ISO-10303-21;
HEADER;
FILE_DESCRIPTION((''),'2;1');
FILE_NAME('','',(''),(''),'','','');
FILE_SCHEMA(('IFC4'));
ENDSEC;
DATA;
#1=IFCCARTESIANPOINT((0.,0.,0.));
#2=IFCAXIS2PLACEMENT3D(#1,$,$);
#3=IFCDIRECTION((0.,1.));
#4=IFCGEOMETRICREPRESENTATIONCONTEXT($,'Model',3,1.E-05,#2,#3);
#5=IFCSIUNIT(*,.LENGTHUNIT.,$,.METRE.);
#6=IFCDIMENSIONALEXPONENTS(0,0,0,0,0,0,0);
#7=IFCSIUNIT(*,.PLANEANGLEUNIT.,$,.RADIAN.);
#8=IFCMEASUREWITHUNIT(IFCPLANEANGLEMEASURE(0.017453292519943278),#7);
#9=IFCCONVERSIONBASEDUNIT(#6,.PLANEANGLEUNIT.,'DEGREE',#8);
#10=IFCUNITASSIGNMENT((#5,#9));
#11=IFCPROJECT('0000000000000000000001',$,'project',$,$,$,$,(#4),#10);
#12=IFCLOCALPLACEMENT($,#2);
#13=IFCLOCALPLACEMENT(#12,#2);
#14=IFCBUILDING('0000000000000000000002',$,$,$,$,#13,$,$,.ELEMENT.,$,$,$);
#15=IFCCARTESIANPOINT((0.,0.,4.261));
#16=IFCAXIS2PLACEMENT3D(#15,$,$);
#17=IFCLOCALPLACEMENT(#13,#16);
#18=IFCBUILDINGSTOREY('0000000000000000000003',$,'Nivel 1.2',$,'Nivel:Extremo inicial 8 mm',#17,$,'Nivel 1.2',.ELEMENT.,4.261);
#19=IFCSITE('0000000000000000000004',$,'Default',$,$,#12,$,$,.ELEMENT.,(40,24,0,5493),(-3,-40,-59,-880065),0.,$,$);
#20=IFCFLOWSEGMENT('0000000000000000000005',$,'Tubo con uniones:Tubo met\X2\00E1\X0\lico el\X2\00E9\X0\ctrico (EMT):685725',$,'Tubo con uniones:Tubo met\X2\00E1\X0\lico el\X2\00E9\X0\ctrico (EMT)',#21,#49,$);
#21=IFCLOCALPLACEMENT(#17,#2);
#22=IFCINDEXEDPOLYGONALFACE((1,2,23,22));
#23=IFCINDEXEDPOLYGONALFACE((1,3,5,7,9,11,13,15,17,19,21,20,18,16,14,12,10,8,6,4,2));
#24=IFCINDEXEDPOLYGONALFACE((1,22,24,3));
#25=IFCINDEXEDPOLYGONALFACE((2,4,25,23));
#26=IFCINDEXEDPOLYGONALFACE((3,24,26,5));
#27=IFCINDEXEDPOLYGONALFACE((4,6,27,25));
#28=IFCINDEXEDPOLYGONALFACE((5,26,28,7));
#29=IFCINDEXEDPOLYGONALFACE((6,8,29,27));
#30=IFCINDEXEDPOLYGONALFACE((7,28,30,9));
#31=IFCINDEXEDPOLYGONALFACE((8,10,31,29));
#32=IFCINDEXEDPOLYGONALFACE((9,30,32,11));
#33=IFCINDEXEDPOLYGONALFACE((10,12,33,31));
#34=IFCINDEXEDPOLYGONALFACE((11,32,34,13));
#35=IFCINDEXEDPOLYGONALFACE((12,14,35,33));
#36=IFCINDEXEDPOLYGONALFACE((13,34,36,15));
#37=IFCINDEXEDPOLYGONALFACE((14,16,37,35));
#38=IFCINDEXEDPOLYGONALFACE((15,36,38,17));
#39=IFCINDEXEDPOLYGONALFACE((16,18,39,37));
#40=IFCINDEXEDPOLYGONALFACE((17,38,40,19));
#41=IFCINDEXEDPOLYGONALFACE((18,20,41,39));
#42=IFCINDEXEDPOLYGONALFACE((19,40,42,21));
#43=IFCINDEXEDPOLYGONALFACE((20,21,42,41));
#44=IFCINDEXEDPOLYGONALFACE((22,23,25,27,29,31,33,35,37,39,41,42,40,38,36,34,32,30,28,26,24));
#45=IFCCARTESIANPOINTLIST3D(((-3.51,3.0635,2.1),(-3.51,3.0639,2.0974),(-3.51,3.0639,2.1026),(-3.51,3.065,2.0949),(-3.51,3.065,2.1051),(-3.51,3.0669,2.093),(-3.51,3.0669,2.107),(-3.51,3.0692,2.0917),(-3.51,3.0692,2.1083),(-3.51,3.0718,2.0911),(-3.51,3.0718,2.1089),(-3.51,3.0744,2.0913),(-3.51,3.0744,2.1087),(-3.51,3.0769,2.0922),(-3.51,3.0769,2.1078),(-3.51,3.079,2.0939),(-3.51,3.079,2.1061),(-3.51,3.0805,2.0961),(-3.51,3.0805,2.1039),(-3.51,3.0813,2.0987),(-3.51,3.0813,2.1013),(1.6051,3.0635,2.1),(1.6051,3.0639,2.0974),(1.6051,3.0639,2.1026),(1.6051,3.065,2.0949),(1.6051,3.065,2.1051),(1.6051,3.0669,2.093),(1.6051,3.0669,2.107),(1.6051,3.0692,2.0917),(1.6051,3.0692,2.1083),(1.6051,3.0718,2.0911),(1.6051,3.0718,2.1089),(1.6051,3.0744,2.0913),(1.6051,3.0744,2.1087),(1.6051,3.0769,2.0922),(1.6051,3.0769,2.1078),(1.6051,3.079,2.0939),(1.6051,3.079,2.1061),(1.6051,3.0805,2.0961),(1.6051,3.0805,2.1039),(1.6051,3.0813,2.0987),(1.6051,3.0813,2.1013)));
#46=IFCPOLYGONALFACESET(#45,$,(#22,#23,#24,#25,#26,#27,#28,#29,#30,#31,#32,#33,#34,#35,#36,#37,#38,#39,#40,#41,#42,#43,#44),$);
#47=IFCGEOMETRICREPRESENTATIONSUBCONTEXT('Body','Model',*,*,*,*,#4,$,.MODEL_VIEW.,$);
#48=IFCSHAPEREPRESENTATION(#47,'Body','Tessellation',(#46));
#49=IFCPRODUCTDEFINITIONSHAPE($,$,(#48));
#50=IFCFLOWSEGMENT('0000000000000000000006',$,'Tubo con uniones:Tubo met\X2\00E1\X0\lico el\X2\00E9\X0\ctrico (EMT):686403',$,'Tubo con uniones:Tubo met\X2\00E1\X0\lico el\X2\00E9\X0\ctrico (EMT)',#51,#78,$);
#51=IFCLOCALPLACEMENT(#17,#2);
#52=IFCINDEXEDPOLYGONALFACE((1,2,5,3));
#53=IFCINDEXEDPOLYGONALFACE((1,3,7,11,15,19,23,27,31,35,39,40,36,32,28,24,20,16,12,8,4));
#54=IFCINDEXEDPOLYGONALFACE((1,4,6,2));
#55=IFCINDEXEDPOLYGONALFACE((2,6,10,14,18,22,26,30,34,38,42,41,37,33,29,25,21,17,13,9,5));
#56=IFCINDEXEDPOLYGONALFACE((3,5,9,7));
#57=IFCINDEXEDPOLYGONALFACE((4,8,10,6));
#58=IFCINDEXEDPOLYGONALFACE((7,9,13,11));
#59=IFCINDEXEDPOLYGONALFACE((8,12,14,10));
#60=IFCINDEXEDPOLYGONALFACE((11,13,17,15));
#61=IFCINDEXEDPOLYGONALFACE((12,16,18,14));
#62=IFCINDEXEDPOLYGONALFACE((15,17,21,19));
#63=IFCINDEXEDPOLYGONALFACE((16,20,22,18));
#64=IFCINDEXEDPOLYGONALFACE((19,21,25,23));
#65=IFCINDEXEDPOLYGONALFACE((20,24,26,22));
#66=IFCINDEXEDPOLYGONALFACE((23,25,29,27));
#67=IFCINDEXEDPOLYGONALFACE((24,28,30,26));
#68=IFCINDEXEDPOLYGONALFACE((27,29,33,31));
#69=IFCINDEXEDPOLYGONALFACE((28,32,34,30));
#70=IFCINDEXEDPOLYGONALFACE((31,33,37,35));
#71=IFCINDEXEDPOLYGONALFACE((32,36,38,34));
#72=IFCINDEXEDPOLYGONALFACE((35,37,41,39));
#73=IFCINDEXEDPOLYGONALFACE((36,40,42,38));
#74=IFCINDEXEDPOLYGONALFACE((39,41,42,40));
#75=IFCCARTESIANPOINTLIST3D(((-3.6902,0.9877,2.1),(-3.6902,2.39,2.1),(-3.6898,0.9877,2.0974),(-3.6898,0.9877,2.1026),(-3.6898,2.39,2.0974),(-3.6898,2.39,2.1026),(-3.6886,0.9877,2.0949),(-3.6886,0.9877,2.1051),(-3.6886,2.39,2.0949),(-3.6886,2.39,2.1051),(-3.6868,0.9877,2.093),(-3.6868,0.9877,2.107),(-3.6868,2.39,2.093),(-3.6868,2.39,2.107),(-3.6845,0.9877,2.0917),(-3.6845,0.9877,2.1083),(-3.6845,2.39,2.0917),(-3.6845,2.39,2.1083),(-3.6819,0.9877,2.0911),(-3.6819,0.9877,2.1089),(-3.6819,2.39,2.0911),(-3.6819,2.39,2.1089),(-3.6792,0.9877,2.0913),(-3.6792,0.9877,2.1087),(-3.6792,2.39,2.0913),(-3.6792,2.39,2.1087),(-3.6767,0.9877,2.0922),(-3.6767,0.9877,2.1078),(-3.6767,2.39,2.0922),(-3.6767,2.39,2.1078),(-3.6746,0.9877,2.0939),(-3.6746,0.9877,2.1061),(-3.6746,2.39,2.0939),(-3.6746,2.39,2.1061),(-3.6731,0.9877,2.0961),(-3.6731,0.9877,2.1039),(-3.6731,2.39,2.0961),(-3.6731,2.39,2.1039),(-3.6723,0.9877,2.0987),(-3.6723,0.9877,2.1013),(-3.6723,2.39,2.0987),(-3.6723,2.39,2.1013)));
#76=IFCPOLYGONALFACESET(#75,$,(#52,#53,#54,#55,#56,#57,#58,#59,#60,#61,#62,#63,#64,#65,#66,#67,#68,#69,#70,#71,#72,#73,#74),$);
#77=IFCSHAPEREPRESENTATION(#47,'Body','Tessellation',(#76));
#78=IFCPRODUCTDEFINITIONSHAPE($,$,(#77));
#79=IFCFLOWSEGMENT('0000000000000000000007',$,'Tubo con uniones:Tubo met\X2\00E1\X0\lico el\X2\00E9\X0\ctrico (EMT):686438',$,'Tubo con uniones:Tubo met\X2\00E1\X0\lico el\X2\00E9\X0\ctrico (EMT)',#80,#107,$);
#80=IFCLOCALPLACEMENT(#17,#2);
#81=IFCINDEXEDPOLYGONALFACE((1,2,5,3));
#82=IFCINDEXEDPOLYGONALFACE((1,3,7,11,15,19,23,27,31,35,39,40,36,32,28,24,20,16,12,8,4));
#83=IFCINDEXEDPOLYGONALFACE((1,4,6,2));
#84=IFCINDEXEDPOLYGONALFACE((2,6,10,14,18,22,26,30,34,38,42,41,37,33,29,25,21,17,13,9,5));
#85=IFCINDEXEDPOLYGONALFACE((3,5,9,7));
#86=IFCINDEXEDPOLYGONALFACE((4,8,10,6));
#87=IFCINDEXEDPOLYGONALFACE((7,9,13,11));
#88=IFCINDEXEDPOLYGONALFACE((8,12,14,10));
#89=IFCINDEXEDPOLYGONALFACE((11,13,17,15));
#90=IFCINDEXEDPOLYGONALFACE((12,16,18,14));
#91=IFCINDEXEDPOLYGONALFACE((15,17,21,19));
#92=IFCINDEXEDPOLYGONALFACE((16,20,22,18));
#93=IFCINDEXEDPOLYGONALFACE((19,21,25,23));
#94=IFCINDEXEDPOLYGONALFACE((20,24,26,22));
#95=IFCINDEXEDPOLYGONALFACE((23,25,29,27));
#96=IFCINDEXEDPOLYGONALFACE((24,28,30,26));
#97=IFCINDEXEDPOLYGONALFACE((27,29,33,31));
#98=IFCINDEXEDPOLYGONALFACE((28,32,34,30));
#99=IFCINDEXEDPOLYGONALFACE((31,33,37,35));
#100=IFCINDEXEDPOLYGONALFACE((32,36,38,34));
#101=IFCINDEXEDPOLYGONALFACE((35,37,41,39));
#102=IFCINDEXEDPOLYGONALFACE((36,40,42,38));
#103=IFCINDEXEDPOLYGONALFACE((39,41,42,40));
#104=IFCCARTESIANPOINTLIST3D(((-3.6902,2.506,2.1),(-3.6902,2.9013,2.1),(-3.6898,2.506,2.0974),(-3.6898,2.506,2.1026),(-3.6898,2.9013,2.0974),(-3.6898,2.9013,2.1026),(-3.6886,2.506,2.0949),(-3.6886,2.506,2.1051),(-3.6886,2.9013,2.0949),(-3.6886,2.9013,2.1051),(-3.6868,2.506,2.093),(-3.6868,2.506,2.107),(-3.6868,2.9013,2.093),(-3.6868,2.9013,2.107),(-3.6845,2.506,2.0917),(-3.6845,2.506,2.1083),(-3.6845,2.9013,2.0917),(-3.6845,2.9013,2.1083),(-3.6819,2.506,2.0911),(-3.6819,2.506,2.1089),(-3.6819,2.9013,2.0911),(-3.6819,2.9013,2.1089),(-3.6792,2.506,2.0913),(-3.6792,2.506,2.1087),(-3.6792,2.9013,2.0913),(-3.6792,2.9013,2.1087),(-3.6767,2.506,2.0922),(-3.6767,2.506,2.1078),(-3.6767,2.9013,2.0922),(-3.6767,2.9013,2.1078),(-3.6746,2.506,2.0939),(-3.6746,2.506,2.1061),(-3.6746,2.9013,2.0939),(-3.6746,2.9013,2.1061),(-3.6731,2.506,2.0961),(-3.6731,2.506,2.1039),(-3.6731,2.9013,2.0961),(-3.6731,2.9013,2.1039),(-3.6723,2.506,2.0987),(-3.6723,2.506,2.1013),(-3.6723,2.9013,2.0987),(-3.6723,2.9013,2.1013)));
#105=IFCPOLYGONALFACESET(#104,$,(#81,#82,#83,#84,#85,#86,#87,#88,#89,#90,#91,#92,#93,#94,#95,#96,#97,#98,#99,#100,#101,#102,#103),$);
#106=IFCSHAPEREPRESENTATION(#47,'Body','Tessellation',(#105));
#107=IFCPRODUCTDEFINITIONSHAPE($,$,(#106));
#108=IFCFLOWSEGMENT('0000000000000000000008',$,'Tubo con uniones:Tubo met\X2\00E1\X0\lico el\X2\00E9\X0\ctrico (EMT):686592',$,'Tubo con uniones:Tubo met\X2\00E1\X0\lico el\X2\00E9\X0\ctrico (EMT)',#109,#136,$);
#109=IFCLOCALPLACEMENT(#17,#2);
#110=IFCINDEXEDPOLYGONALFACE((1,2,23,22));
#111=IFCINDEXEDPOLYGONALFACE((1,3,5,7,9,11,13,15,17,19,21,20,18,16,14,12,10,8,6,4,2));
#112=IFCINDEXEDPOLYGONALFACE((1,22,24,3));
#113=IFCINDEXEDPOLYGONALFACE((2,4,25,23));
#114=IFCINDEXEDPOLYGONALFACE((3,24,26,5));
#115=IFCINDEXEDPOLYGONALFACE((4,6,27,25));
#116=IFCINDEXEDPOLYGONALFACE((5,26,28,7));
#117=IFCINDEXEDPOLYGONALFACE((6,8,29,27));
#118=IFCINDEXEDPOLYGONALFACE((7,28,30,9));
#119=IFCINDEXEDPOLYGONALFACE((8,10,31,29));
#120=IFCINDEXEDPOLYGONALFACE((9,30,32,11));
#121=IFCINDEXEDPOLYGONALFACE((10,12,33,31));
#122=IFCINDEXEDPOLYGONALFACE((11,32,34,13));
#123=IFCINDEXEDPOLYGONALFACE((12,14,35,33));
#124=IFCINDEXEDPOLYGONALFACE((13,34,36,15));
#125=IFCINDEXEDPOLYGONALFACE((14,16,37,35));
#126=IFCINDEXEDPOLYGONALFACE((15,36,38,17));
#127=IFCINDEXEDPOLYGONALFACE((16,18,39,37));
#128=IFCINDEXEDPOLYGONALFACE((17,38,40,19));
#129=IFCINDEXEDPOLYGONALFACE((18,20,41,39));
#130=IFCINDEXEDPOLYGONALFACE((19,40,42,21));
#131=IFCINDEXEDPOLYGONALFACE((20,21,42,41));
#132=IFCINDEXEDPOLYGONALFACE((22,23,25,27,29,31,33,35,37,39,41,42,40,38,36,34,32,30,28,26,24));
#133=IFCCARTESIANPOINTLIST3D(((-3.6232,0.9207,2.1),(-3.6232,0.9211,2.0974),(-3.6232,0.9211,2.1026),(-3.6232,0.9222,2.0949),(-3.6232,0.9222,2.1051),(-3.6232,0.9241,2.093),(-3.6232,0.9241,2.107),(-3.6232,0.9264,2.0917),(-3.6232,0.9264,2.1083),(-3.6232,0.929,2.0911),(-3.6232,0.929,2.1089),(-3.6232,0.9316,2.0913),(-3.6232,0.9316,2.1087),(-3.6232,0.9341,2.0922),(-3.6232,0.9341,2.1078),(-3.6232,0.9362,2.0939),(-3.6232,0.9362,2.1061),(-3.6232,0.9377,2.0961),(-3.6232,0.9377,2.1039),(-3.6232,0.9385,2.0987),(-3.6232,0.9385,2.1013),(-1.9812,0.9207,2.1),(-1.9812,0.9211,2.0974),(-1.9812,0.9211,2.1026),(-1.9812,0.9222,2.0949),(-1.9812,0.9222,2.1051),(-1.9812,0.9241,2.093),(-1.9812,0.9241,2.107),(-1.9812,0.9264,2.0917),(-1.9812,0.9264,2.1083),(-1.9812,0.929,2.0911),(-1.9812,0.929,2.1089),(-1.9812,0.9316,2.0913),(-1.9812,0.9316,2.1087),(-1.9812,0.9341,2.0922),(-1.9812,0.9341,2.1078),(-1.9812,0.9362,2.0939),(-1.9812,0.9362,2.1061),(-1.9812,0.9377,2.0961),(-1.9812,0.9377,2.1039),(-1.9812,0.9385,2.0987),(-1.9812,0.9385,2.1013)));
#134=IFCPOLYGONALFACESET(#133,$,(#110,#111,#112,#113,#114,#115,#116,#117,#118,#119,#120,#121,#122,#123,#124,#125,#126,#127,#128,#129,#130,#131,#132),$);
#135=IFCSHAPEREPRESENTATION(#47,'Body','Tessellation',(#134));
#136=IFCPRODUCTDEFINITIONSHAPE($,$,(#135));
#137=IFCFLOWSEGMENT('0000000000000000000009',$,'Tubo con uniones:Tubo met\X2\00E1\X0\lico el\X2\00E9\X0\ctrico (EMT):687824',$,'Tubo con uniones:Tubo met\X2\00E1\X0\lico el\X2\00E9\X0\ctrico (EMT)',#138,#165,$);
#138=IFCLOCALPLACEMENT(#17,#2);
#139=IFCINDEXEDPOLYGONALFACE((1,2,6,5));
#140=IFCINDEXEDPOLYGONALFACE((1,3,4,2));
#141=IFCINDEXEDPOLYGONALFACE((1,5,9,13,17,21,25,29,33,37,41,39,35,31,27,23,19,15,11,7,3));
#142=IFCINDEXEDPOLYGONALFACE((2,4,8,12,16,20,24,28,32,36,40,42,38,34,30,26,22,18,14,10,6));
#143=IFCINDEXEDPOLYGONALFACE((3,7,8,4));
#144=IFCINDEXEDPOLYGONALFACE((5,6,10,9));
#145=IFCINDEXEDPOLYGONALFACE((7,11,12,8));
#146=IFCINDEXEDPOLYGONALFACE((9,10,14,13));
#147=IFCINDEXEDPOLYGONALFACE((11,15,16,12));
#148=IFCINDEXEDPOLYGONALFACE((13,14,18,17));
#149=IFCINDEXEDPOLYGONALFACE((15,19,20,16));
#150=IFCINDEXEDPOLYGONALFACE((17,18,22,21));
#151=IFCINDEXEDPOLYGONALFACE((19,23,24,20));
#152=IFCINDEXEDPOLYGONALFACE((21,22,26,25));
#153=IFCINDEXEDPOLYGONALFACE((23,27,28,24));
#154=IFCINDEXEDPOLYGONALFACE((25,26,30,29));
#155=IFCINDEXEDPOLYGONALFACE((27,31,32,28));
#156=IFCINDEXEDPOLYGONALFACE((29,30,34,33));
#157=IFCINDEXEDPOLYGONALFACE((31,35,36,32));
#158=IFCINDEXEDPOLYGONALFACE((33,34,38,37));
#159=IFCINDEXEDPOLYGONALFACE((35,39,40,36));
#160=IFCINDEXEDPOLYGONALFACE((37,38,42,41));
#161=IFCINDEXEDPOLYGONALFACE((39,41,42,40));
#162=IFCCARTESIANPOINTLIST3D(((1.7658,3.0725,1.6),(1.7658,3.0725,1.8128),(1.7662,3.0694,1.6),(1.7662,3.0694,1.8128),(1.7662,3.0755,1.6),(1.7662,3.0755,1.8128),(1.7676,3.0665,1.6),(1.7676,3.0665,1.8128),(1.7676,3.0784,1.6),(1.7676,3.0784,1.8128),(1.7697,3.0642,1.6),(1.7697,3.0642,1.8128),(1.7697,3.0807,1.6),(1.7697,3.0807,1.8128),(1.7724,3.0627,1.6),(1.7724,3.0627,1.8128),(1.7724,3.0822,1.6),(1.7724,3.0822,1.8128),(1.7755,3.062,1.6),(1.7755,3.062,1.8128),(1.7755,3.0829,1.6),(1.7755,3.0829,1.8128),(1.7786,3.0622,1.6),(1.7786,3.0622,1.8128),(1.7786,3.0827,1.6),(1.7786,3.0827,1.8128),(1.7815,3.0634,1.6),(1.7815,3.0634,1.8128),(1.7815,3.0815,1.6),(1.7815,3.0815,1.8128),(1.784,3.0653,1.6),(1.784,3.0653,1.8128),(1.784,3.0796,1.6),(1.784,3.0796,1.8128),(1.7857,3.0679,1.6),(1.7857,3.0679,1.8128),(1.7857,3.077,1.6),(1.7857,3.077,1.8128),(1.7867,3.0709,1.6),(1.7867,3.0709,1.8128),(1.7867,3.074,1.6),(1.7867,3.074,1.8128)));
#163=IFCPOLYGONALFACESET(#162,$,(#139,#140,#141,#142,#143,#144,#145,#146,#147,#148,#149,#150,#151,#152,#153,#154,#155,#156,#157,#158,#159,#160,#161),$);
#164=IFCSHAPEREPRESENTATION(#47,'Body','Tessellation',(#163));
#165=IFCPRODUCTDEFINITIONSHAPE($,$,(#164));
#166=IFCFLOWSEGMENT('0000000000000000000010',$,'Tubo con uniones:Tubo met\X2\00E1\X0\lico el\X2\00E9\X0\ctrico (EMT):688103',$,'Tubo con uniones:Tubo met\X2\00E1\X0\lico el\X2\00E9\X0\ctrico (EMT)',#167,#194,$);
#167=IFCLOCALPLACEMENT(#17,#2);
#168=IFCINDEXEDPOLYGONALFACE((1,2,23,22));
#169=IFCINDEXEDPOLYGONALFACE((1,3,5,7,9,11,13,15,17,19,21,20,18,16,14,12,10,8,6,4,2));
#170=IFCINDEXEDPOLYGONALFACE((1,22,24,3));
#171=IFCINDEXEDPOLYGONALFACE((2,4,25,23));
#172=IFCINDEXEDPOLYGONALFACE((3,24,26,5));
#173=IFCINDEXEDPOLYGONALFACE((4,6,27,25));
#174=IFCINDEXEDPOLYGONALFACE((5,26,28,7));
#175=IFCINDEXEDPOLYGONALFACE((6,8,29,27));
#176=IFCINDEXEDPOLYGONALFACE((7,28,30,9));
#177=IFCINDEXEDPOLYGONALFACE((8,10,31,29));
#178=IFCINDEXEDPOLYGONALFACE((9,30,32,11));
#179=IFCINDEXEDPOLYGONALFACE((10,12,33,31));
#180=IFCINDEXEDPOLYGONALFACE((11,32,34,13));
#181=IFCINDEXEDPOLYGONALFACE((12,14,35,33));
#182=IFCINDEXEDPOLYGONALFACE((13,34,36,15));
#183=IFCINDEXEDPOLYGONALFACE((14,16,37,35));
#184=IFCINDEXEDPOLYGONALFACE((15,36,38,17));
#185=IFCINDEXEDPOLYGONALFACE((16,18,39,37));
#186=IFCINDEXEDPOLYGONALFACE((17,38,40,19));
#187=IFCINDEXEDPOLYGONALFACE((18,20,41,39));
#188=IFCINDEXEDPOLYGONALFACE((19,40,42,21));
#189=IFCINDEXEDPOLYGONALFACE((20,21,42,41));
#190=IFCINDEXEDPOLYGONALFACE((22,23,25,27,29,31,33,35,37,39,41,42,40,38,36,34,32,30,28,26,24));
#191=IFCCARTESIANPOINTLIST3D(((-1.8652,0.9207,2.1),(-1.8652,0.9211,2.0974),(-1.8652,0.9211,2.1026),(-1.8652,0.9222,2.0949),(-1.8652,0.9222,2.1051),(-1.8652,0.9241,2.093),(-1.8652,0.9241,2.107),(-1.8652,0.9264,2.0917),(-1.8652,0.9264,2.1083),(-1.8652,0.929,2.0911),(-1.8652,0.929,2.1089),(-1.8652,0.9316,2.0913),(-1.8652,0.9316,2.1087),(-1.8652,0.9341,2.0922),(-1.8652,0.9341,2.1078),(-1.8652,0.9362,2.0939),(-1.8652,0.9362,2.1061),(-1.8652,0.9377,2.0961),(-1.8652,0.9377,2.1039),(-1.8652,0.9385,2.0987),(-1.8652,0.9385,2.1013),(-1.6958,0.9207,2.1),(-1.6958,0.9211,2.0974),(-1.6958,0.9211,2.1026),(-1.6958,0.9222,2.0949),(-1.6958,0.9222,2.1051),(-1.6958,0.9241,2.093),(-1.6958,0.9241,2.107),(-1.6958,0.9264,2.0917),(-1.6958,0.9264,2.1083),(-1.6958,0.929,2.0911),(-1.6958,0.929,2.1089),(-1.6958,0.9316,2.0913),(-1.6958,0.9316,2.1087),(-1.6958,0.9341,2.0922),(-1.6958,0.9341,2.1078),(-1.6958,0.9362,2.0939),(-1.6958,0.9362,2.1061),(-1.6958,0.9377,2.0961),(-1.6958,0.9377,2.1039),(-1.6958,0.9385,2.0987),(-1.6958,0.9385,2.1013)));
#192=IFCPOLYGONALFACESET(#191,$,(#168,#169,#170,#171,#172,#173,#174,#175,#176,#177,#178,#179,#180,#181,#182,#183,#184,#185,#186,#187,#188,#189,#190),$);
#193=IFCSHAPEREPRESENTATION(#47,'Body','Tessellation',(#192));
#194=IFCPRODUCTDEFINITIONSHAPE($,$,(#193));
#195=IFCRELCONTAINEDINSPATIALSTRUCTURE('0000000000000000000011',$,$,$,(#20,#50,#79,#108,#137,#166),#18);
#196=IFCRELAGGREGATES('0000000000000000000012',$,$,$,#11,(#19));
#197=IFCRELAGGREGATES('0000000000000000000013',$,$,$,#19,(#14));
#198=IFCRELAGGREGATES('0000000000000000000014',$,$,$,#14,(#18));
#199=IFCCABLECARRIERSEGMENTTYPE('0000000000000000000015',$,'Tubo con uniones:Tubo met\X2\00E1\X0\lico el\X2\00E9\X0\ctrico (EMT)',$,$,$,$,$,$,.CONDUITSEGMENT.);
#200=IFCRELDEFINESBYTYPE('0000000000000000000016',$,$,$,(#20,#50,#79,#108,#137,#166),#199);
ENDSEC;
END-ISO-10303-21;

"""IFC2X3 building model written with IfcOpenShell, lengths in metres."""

from ifc_helpers import new_model, entity, si_unit, converted_unit, direction, frame, frame_2d, origin, origin_2d_with_axis, place, context, subcontext, project, spatial, circle, extrude, type_object, element, save


model = new_model("IFC2X3")

# Units and contexts
model_context = context("Model", 3, precision=1e-05, world=origin(), true_north=direction((0.0, 1.0)))
body_context = subcontext(model_context, "Body", "Model", "MODEL_VIEW")
ifc_project = project(units=[si_unit("LENGTHUNIT", "METRE"), converted_unit("PLANEANGLEUNIT", "DEGREE", entity("IfcPlaneAngleMeasure", 0.017453292519943278), si_unit("PLANEANGLEUNIT", "RADIAN"), dimensions=[0, 0, 0, 0, 0, 0, 0])], contexts=[model_context])

# Site, building, storey
site_placement = place(None, origin())
site = spatial("IfcSite", under=ifc_project, at=site_placement, Name="Default", CompositionType="ELEMENT", RefLatitude=(40, 24, 0, 5493), RefLongitude=(-3, -40, -59, -880065), RefElevation=0.0)
building_placement = place(site_placement, origin())
building = spatial("IfcBuilding", under=site, at=building_placement, CompositionType="ELEMENT")
storey_placement = place(building_placement, frame((0.0, 0.0, 4.261)))
storey = spatial("IfcBuildingStorey", under=building, at=storey_placement, Name="Nivel 1.2", ObjectType="Nivel:Extremo inicial 8 mm", LongName="Nivel 1.2", CompositionType="ELEMENT", Elevation=4.261)

# Flow segments
cable_carrier_segment_type_1 = type_object("IfcCableCarrierSegmentType", Name="Tubo con uniones:Tubo metálico eléctrico (EMT)", PredefinedType="CONDUITSEGMENT")
flow_segment_1_placement = place(storey_placement, origin())
element("IfcFlowSegment", 1, at=flow_segment_1_placement, inside=storey, type_object=cable_carrier_segment_type_1, Name="Tubo con uniones:Tubo metálico eléctrico (EMT):685725", ObjectType="Tubo con uniones:Tubo metálico eléctrico (EMT)", context=body_context, shape_type="SweptSolid", body=[
    extrude(circle(Radius=0.009, at=frame_2d((0.0, 0.0), x_axis=(1.0, 0.0))), frame((-3.51, 3.0725, 2.1), z_axis=(1.0, 0.0, 0.0), x_axis=(0.0, -1.0, 0.0)), (0.0, 0.0, 1.0), 5.1151),
])
flow_segment_2_placement = place(storey_placement, origin())
element("IfcFlowSegment", 2, at=flow_segment_2_placement, inside=storey, type_object=cable_carrier_segment_type_1, Name="Tubo con uniones:Tubo metálico eléctrico (EMT):686403", ObjectType="Tubo con uniones:Tubo metálico eléctrico (EMT)", context=body_context, shape_type="SweptSolid", body=[
    extrude(circle(Radius=0.009, at=origin_2d_with_axis()), frame((-3.6812, 0.9877, 2.1), z_axis=(0.0, 1.0, 0.0), x_axis=(-1.0, 0.0, 0.0)), (0.0, 0.0, 1.0), 1.4024),
])
flow_segment_3_placement = place(storey_placement, origin())
element("IfcFlowSegment", 3, at=flow_segment_3_placement, inside=storey, type_object=cable_carrier_segment_type_1, Name="Tubo con uniones:Tubo metálico eléctrico (EMT):686438", ObjectType="Tubo con uniones:Tubo metálico eléctrico (EMT)", context=body_context, shape_type="SweptSolid", body=[
    extrude(circle(Radius=0.009, at=frame_2d((0.0, 0.0), x_axis=(1.0, 0.0))), frame((-3.6812, 2.506, 2.1), z_axis=(0.0, 1.0, 0.0), x_axis=(-1.0, 0.0, 0.0)), (0.0, 0.0, 1.0), 0.3953),
])
flow_segment_4_placement = place(storey_placement, origin())
element("IfcFlowSegment", 4, at=flow_segment_4_placement, inside=storey, type_object=cable_carrier_segment_type_1, Name="Tubo con uniones:Tubo metálico eléctrico (EMT):686592", ObjectType="Tubo con uniones:Tubo metálico eléctrico (EMT)", context=body_context, shape_type="SweptSolid", body=[
    extrude(circle(Radius=0.009, at=origin_2d_with_axis()), frame((-3.6232, 0.9297, 2.1), z_axis=(1.0, 0.0, 0.0), x_axis=(0.0, -1.0, 0.0)), (0.0, 0.0, 1.0), 1.642),
])
flow_segment_5_placement = place(storey_placement, origin())
element("IfcFlowSegment", 5, at=flow_segment_5_placement, inside=storey, type_object=cable_carrier_segment_type_1, Name="Tubo con uniones:Tubo metálico eléctrico (EMT):687824", ObjectType="Tubo con uniones:Tubo metálico eléctrico (EMT)", context=body_context, shape_type="SweptSolid", body=[
    extrude(circle(Radius=0.0105, at=origin_2d_with_axis()), frame((1.7763, 3.0725, 1.6), z_axis=(0.0, 0.0, 1.0), x_axis=(-1.0, 0.0, 0.0)), (0.0, 0.0, 1.0), 0.2128),
])
flow_segment_6_placement = place(storey_placement, origin())
element("IfcFlowSegment", 6, at=flow_segment_6_placement, inside=storey, type_object=cable_carrier_segment_type_1, Name="Tubo con uniones:Tubo metálico eléctrico (EMT):688103", ObjectType="Tubo con uniones:Tubo metálico eléctrico (EMT)", context=body_context, shape_type="SweptSolid", body=[
    extrude(circle(Radius=0.009, at=frame_2d((0.0, 0.0), x_axis=(1.0, 0.0))), frame((-1.8652, 0.9297, 2.1), z_axis=(1.0, 0.0, 0.0), x_axis=(0.0, -1.0, 0.0)), (0.0, 0.0, 1.0), 0.1694),
])

save(model, "model.ifc")
